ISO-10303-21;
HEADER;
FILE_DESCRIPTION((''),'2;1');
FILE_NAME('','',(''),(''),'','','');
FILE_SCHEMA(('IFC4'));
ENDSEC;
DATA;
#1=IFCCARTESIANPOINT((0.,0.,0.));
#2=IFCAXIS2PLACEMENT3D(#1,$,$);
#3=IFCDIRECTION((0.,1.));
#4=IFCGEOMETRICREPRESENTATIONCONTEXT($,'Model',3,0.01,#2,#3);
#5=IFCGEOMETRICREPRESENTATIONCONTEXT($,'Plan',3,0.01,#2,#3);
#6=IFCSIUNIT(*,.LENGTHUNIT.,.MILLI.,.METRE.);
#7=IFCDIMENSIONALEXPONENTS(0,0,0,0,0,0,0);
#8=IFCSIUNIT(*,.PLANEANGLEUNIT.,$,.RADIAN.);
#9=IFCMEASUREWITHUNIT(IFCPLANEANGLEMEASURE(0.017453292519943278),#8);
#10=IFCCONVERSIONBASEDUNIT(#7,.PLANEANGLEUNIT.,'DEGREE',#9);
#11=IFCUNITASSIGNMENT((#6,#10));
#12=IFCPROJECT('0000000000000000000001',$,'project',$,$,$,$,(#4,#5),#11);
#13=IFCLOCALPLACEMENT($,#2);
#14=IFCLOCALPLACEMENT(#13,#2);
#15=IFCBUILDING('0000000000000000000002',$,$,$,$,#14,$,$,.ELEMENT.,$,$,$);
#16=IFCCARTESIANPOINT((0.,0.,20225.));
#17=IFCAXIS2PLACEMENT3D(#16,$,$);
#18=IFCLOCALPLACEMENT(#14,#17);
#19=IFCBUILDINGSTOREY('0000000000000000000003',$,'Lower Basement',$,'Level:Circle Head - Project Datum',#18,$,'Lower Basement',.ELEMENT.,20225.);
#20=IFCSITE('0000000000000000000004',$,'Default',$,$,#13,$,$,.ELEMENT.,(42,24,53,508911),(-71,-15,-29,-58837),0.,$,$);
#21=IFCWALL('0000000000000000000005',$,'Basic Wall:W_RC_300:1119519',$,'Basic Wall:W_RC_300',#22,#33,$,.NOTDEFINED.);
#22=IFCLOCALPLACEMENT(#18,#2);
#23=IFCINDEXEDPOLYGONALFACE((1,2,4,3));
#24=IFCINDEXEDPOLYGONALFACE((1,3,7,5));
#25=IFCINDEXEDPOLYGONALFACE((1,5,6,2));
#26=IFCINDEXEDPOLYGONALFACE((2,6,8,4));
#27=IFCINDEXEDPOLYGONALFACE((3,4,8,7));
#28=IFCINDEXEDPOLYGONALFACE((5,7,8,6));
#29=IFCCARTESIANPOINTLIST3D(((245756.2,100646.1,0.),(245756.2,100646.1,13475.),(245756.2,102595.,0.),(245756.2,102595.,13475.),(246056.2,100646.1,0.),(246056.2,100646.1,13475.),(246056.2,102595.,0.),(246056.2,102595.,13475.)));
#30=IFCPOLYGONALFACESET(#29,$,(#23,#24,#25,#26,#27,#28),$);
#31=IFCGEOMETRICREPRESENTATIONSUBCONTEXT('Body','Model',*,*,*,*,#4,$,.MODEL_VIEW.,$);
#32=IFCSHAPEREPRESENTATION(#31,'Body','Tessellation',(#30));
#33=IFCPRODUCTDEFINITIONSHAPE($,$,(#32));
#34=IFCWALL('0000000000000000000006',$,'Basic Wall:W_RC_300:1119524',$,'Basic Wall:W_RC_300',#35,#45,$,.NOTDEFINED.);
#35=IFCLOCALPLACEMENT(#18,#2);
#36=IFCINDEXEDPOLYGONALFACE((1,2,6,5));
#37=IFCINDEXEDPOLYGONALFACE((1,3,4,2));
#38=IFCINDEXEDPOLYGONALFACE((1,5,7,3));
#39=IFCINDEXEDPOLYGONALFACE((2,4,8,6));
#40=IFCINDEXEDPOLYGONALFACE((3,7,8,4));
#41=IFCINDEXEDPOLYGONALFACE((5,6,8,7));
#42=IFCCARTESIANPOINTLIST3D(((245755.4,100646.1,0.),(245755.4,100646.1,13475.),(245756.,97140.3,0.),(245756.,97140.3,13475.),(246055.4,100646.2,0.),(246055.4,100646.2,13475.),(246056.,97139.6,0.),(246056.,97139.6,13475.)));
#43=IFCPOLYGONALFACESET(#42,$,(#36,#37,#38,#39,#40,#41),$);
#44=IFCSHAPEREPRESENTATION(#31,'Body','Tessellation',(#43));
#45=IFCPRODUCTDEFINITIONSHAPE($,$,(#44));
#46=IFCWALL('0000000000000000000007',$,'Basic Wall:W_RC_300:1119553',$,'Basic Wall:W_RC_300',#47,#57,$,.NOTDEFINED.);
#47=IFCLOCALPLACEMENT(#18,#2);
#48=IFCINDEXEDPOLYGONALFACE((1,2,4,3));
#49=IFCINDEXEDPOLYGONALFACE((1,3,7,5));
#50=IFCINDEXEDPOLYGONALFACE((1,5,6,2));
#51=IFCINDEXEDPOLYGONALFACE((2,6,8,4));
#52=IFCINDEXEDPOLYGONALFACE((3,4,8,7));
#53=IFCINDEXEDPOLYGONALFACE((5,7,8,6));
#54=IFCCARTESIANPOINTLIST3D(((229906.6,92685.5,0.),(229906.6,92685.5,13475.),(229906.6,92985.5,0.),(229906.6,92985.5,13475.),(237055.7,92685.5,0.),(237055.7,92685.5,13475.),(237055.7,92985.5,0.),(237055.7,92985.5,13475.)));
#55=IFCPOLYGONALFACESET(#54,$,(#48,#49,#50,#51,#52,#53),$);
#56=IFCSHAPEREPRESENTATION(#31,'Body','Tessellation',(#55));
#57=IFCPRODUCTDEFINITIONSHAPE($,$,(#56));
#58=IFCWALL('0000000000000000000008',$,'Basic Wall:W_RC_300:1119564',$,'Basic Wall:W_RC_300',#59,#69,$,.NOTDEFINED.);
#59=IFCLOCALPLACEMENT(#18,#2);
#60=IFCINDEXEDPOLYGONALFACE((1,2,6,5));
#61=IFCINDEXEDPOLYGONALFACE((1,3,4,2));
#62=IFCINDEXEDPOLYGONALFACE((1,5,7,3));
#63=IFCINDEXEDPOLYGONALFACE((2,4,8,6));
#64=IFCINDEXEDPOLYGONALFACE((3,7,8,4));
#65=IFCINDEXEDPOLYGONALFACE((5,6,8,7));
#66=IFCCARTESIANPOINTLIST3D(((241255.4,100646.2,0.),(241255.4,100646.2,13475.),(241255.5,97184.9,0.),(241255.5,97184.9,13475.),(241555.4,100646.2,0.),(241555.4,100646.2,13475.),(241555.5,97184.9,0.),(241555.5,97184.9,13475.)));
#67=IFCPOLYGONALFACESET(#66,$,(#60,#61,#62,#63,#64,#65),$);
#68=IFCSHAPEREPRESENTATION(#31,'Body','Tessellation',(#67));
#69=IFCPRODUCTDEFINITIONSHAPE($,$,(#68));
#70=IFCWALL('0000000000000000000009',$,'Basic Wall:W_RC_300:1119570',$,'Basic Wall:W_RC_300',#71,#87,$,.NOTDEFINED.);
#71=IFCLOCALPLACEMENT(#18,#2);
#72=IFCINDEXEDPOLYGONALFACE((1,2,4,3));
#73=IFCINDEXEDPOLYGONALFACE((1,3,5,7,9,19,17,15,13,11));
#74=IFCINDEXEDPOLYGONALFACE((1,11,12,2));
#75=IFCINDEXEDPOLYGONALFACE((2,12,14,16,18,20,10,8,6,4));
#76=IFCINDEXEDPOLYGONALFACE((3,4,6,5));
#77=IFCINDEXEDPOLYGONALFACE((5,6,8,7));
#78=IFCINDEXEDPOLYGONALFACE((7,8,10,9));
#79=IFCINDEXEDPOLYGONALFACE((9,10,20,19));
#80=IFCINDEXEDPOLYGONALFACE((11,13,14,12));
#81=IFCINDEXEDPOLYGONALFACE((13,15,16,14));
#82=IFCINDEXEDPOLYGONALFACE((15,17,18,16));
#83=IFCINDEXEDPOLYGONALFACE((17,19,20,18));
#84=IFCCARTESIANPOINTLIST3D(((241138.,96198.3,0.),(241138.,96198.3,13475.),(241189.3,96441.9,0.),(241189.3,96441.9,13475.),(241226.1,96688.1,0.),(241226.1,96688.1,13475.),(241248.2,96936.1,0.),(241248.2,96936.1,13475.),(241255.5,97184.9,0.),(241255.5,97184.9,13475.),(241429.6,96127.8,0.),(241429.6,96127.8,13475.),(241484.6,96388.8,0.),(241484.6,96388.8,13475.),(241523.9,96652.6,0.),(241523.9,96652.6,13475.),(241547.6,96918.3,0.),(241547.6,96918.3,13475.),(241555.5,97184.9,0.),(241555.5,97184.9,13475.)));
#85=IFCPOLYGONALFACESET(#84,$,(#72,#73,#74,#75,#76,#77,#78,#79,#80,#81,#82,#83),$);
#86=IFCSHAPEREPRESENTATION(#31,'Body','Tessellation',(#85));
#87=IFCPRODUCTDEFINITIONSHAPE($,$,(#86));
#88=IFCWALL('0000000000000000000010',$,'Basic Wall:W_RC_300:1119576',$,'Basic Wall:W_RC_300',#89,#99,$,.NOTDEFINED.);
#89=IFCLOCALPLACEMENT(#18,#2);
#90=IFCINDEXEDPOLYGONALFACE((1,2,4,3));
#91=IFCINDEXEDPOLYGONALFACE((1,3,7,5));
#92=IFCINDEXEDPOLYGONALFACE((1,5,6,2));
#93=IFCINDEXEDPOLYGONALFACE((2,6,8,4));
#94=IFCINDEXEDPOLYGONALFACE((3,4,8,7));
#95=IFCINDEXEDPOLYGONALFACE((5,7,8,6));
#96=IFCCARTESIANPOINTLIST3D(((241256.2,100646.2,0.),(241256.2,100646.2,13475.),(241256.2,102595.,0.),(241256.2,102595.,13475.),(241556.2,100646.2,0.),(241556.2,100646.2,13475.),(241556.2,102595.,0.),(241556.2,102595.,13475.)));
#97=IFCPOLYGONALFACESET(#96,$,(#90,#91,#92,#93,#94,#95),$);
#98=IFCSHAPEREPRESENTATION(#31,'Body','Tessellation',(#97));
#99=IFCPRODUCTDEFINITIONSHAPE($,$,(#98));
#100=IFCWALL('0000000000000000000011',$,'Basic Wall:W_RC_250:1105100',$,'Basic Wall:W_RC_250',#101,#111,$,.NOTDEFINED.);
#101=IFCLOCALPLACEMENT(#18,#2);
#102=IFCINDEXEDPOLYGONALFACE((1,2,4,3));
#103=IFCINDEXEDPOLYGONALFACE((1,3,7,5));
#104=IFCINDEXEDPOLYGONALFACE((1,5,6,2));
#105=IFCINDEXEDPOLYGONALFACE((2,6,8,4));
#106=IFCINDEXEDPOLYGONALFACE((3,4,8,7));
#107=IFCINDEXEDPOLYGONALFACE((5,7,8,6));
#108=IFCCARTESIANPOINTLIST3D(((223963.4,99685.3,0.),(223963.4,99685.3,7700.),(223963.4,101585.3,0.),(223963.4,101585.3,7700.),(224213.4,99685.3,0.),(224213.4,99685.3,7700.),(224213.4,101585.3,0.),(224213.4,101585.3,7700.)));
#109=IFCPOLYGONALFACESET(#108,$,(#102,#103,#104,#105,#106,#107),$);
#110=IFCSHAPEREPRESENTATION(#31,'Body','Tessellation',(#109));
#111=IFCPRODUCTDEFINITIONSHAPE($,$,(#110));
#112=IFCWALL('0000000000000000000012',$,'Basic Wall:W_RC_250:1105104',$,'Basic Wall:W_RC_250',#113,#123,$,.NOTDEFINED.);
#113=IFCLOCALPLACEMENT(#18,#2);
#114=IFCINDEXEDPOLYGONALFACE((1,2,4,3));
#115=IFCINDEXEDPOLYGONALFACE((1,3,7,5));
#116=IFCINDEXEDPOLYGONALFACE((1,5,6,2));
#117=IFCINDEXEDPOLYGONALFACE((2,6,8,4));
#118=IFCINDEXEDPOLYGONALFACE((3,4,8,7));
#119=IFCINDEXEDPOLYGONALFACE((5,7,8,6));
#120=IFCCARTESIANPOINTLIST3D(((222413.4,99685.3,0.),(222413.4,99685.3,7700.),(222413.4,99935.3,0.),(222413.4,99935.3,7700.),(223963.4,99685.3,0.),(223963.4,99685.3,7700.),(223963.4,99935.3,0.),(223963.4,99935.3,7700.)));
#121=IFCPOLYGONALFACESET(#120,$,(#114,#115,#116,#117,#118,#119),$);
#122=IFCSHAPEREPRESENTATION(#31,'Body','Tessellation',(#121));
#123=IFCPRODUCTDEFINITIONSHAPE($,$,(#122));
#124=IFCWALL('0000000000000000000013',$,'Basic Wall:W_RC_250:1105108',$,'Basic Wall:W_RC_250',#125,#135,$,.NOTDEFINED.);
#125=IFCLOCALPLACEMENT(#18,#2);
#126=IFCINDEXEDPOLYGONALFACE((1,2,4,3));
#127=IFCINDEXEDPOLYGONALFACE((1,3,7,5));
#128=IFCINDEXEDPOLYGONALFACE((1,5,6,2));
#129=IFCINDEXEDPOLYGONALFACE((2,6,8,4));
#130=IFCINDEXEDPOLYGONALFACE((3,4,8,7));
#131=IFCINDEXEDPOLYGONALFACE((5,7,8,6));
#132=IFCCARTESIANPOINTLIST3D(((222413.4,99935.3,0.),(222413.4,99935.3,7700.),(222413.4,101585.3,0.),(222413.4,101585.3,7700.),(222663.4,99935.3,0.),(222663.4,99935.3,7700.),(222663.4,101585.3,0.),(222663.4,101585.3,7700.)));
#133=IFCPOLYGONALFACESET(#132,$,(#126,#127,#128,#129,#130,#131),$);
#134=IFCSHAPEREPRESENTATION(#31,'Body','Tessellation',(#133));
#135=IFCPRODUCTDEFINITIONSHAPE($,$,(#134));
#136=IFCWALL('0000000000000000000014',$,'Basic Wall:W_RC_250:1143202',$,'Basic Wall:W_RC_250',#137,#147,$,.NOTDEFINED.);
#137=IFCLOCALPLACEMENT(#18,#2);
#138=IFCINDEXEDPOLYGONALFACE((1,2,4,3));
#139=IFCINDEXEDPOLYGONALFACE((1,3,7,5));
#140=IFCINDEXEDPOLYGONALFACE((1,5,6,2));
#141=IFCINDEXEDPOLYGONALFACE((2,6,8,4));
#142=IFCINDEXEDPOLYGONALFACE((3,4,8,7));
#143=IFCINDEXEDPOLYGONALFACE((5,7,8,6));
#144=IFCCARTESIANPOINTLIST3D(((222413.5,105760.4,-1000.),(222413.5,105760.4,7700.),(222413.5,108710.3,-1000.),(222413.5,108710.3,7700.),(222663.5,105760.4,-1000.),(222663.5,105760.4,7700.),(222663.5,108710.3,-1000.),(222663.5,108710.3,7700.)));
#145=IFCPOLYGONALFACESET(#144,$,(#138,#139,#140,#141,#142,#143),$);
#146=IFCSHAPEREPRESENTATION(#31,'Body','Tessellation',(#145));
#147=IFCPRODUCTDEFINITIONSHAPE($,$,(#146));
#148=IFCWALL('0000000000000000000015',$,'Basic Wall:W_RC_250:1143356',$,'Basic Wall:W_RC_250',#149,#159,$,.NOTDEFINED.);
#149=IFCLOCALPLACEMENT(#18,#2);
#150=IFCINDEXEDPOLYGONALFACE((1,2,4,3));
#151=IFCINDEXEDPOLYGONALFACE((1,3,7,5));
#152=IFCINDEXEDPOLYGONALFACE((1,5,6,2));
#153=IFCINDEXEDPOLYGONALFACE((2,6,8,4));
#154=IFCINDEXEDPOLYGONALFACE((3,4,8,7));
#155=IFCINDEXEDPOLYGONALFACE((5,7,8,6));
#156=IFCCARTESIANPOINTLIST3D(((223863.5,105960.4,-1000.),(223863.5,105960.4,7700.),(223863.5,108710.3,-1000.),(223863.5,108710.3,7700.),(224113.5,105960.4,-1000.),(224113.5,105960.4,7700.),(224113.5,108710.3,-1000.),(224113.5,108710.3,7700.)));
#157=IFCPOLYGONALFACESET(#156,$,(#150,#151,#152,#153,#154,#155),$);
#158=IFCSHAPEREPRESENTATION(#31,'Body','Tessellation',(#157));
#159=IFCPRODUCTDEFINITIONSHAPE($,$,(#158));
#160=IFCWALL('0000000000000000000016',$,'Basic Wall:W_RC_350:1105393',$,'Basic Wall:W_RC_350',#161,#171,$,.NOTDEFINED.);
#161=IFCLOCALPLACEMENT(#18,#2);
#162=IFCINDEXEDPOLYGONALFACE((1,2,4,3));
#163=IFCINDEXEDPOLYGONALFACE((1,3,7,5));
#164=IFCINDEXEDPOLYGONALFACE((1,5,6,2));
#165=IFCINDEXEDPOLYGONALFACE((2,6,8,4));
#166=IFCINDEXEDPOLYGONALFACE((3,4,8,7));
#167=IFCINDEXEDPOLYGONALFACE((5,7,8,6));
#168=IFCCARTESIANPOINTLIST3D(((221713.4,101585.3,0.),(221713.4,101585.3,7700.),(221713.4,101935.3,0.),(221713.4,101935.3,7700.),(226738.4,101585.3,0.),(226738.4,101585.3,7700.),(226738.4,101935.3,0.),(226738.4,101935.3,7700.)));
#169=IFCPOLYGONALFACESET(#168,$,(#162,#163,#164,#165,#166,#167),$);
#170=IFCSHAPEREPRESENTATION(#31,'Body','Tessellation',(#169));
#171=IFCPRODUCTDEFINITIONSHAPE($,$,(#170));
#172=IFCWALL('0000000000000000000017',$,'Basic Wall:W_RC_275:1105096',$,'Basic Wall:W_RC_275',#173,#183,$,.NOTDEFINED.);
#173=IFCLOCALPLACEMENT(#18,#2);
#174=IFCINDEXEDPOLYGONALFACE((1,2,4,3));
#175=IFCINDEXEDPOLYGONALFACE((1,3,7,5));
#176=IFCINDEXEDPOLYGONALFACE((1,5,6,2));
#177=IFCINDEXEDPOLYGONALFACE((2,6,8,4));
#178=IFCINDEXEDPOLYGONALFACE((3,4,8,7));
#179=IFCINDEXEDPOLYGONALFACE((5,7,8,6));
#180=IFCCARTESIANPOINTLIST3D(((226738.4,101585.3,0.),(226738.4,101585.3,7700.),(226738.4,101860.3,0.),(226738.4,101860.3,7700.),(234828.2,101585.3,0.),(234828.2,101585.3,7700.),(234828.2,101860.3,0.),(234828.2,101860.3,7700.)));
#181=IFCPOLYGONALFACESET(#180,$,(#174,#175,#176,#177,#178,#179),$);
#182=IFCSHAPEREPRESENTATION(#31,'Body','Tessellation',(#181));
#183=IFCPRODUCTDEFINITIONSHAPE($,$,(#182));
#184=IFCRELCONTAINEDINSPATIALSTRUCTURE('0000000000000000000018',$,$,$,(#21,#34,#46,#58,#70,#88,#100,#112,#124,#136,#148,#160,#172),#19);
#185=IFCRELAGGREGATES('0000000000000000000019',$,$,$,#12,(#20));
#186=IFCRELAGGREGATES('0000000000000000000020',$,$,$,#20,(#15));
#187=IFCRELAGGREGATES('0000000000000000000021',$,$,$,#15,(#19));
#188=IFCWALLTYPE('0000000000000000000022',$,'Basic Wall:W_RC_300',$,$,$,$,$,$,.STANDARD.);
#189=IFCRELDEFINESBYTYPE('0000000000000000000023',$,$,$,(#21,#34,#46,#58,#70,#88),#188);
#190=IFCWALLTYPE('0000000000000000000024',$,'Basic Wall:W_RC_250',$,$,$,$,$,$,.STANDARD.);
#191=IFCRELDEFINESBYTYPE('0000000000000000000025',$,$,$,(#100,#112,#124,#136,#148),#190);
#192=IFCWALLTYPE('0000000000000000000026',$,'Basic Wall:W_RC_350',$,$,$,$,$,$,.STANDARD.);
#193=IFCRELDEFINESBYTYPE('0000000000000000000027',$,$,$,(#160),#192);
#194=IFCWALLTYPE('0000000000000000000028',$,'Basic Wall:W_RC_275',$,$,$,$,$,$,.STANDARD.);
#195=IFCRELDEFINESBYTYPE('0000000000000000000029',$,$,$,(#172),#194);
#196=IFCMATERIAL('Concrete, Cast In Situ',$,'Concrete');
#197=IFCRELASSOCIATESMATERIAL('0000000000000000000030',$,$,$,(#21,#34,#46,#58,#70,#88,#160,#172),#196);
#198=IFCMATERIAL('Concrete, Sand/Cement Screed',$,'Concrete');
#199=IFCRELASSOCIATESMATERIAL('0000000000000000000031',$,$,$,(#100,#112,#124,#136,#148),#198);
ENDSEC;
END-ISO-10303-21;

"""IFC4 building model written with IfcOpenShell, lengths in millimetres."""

from ifc_helpers import new_model, entity, si_unit, converted_unit, direction, frame, origin, place, context, subcontext, project, spatial, line, arc, indexed_curve, outline, extrude, material, type_object, element, save


model = new_model("IFC4")

# Units and contexts
model_context = context("Model", 3, precision=0.01, world=origin(), true_north=direction((0.0, 1.0)))
plan_context = context("Plan", 3, precision=0.01, world=origin(), true_north=direction((0.0, 1.0)))
body_context = subcontext(model_context, "Body", "Model", "MODEL_VIEW")
ifc_project = project(units=[si_unit("LENGTHUNIT", "METRE", prefix="MILLI"), converted_unit("PLANEANGLEUNIT", "DEGREE", entity("IfcPlaneAngleMeasure", 0.017453292519943278), si_unit("PLANEANGLEUNIT", "RADIAN"), dimensions=[0, 0, 0, 0, 0, 0, 0])], contexts=[model_context, plan_context])

# Site, building, storey
site_placement = place(None, origin())
site = spatial("IfcSite", under=ifc_project, at=site_placement, Name="Default", CompositionType="ELEMENT", RefLatitude=(42, 24, 53, 508911), RefLongitude=(-71, -15, -29, -58837), RefElevation=0.0)
building_placement = place(site_placement, origin())
building = spatial("IfcBuilding", under=site, at=building_placement, CompositionType="ELEMENT")
storey_placement = place(building_placement, frame((0.0, 0.0, 20225.0)))
storey = spatial("IfcBuildingStorey", under=building, at=storey_placement, Name="Lower Basement", ObjectType="Level:Circle Head - Project Datum", LongName="Lower Basement", CompositionType="ELEMENT", Elevation=20225.0)

# Walls
ifc_material_1 = material(Name="Concrete, Cast In Situ", Category="Concrete")
wall_type_1 = type_object("IfcWallType", Name="Basic Wall:W_RC_300", PredefinedType="STANDARD")
wall_1_placement = place(storey_placement, frame((245906.2, 100646.1, 0.0), z_axis=(0.0, 0.0, 1.0), x_axis=(0.0, 1.0, 0.0)))
element("IfcWall", 1, at=wall_1_placement, inside=storey, type_object=wall_type_1, material=ifc_material_1, Name="Basic Wall:W_RC_300:1119519", ObjectType="Basic Wall:W_RC_300", PredefinedType="NOTDEFINED", context=body_context, shape_type="SweptSolid", body=[
    extrude(outline(indexed_curve([(1948.9, 150.0), (0.0, 150.0), (0.0, -150.0), (1948.9, -150.0), (1948.9, 150.0)], self_intersect=False)), origin(), (0.0, 0.0, 1.0), 13475.0),
])
wall_2_placement = place(storey_placement, frame((245906.0, 97139.6, 0.0), z_axis=(0.0, 0.0, 1.0), x_axis=(-0.000178, 1.0, 0.0)))
element("IfcWall", 2, at=wall_2_placement, inside=storey, type_object=wall_type_1, material=ifc_material_1, Name="Basic Wall:W_RC_300:1119524", ObjectType="Basic Wall:W_RC_300", PredefinedType="NOTDEFINED", context=body_context, shape_type="SweptSolid", body=[
    extrude(outline(indexed_curve([(3506.6, -150.0), (3506.6, 150.0), (0.8, 150.0), (0.0, -150.0), (3506.6, -150.0)], self_intersect=False)), origin(), (0.0, 0.0, 1.0), 13475.0),
])
wall_3_placement = place(storey_placement, frame((237055.7, 92835.5, 0.0), z_axis=(0.0, 0.0, 1.0), x_axis=(-1.0, 0.0, 0.0)))
element("IfcWall", 3, at=wall_3_placement, inside=storey, type_object=wall_type_1, material=ifc_material_1, Name="Basic Wall:W_RC_300:1119553", ObjectType="Basic Wall:W_RC_300", PredefinedType="NOTDEFINED", context=body_context, shape_type="SweptSolid", body=[
    extrude(outline(indexed_curve([(7149.1, 150.0), (0.0, 150.0), (0.0, -150.0), (7149.1, -150.0), (7149.1, 150.0)], self_intersect=False)), origin(), (0.0, 0.0, 1.0), 13475.0),
])
wall_4_placement = place(storey_placement, frame((241405.4, 100646.2, 0.0), z_axis=(0.0, 0.0, 1.0), x_axis=(0.000037, -1.0, 0.0)))
element("IfcWall", 4, at=wall_4_placement, inside=storey, type_object=wall_type_1, material=ifc_material_1, Name="Basic Wall:W_RC_300:1119564", ObjectType="Basic Wall:W_RC_300", PredefinedType="NOTDEFINED", context=body_context, shape_type="SweptSolid", body=[
    extrude(outline(indexed_curve([(3461.3, 150.0), (0.0, 150.0), (0.0, -150.0), (3461.3, -150.0), (3461.3, 150.0)], self_intersect=False)), origin(), (0.0, 0.0, 1.0), 13475.0),
])
wall_5_placement = place(storey_placement, frame((241405.5, 97184.9, 0.0), z_axis=(0.0, 0.0, 1.0), x_axis=(1.0, 0.000178, 0.0)))
element("IfcWall", 5, at=wall_5_placement, inside=storey, type_object=wall_type_1, material=ifc_material_1, Name="Basic Wall:W_RC_300:1119570", ObjectType="Basic Wall:W_RC_300", PredefinedType="NOTDEFINED", context=body_context, shape_type="SweptSolid", body=[
    extrude(outline(indexed_curve([(23.9, -1057.2), (118.3, -532.3), (150.0, 0.0), (-150.0, 0.0), (-179.6, -496.8), (-267.7, -986.6)], segments=[arc(1, 2, 3), line(3, 4), arc(4, 5, 6), line(6, 1)], self_intersect=False)), origin(), (0.0, 0.0, 1.0), 13475.0),
])
wall_6_placement = place(storey_placement, frame((241406.2, 102595.0, 0.0), z_axis=(0.0, 0.0, 1.0), x_axis=(0.0, -1.0, 0.0)))
element("IfcWall", 6, at=wall_6_placement, inside=storey, type_object=wall_type_1, material=ifc_material_1, Name="Basic Wall:W_RC_300:1119576", ObjectType="Basic Wall:W_RC_300", PredefinedType="NOTDEFINED", context=body_context, shape_type="SweptSolid", body=[
    extrude(outline(indexed_curve([(1948.8, 150.0), (0.0, 150.0), (0.0, -150.0), (1948.8, -150.0), (1948.8, 150.0)], self_intersect=False)), origin(), (0.0, 0.0, 1.0), 13475.0),
])
ifc_material_2 = material(Name="Concrete, Sand/Cement Screed", Category="Concrete")
wall_type_2 = type_object("IfcWallType", Name="Basic Wall:W_RC_250", PredefinedType="STANDARD")
wall_7_placement = place(storey_placement, frame((224088.4, 101585.3, 0.0), z_axis=(0.0, 0.0, 1.0), x_axis=(0.0, -1.0, 0.0)))
element("IfcWall", 7, at=wall_7_placement, inside=storey, type_object=wall_type_2, material=ifc_material_2, Name="Basic Wall:W_RC_250:1105100", ObjectType="Basic Wall:W_RC_250", PredefinedType="NOTDEFINED", context=body_context, shape_type="SweptSolid", body=[
    extrude(outline(indexed_curve([(1900.0, 125.0), (0.0, 125.0), (0.0, -125.0), (1900.0, -125.0), (1900.0, 125.0)], self_intersect=False)), origin(), (0.0, 0.0, 1.0), 7700.0),
])
wall_8_placement = place(storey_placement, frame((223963.4, 99810.3, 0.0), z_axis=(0.0, 0.0, 1.0), x_axis=(-1.0, 0.0, 0.0)))
element("IfcWall", 8, at=wall_8_placement, inside=storey, type_object=wall_type_2, material=ifc_material_2, Name="Basic Wall:W_RC_250:1105104", ObjectType="Basic Wall:W_RC_250", PredefinedType="NOTDEFINED", context=body_context, shape_type="SweptSolid", body=[
    extrude(outline(indexed_curve([(1550.0, 125.0), (0.0, 125.0), (0.0, -125.0), (1550.0, -125.0), (1550.0, 125.0)], self_intersect=False)), origin(), (0.0, 0.0, 1.0), 7700.0),
])
wall_9_placement = place(storey_placement, frame((222538.4, 99935.3, 0.0), z_axis=(0.0, 0.0, 1.0), x_axis=(0.0, 1.0, 0.0)))
element("IfcWall", 9, at=wall_9_placement, inside=storey, type_object=wall_type_2, material=ifc_material_2, Name="Basic Wall:W_RC_250:1105108", ObjectType="Basic Wall:W_RC_250", PredefinedType="NOTDEFINED", context=body_context, shape_type="SweptSolid", body=[
    extrude(outline(indexed_curve([(1650.0, 125.0), (0.0, 125.0), (0.0, -125.0), (1650.0, -125.0), (1650.0, 125.0)], self_intersect=False)), origin(), (0.0, 0.0, 1.0), 7700.0),
])
wall_10_placement = place(storey_placement, frame((222538.5, 105760.4, -1000.0), z_axis=(0.0, 0.0, 1.0), x_axis=(0.0, 1.0, 0.0)))
element("IfcWall", 10, at=wall_10_placement, inside=storey, type_object=wall_type_2, material=ifc_material_2, Name="Basic Wall:W_RC_250:1143202", ObjectType="Basic Wall:W_RC_250", PredefinedType="NOTDEFINED", context=body_context, shape_type="SweptSolid", body=[
    extrude(outline(indexed_curve([(2950.0, 125.0), (0.0, 125.0), (0.0, -125.0), (2950.0, -125.0), (2950.0, 125.0)], self_intersect=False)), origin(), (0.0, 0.0, 1.0), 8700.0),
])
wall_11_placement = place(storey_placement, frame((223988.5, 105960.4, -1000.0), z_axis=(0.0, 0.0, 1.0), x_axis=(0.0, 1.0, 0.0)))
element("IfcWall", 11, at=wall_11_placement, inside=storey, type_object=wall_type_2, material=ifc_material_2, Name="Basic Wall:W_RC_250:1143356", ObjectType="Basic Wall:W_RC_250", PredefinedType="NOTDEFINED", context=body_context, shape_type="SweptSolid", body=[
    extrude(outline(indexed_curve([(2750.0, 125.0), (0.0, 125.0), (0.0, -125.0), (2750.0, -125.0), (2750.0, 125.0)], self_intersect=False)), origin(), (0.0, 0.0, 1.0), 8700.0),
])
wall_type_3 = type_object("IfcWallType", Name="Basic Wall:W_RC_350", PredefinedType="STANDARD")
wall_12_placement = place(storey_placement, frame((226738.4, 101760.3, 0.0), z_axis=(0.0, 0.0, 1.0), x_axis=(-1.0, 0.0, 0.0)))
element("IfcWall", 12, at=wall_12_placement, inside=storey, type_object=wall_type_3, material=ifc_material_1, Name="Basic Wall:W_RC_350:1105393", ObjectType="Basic Wall:W_RC_350", PredefinedType="NOTDEFINED", context=body_context, shape_type="SweptSolid", body=[
    extrude(outline(indexed_curve([(5025.0, 175.0), (0.0, 175.0), (0.0, -175.0), (5025.0, -175.0), (5025.0, 175.0)], self_intersect=False)), origin(), (0.0, 0.0, 1.0), 7700.0),
])
wall_type_4 = type_object("IfcWallType", Name="Basic Wall:W_RC_275", PredefinedType="STANDARD")
wall_13_placement = place(storey_placement, frame((234828.2, 101722.8, 0.0), z_axis=(0.0, 0.0, 1.0), x_axis=(-1.0, 0.0, 0.0)))
element("IfcWall", 13, at=wall_13_placement, inside=storey, type_object=wall_type_4, material=ifc_material_1, Name="Basic Wall:W_RC_275:1105096", ObjectType="Basic Wall:W_RC_275", PredefinedType="NOTDEFINED", context=body_context, shape_type="SweptSolid", body=[
    extrude(outline(indexed_curve([(8089.8, 137.5), (0.0, 137.5), (0.0, -137.5), (8089.8, -137.5), (8089.8, 137.5)], self_intersect=False)), origin(), (0.0, 0.0, 1.0), 7700.0),
])

save(model, "model.ifc")
